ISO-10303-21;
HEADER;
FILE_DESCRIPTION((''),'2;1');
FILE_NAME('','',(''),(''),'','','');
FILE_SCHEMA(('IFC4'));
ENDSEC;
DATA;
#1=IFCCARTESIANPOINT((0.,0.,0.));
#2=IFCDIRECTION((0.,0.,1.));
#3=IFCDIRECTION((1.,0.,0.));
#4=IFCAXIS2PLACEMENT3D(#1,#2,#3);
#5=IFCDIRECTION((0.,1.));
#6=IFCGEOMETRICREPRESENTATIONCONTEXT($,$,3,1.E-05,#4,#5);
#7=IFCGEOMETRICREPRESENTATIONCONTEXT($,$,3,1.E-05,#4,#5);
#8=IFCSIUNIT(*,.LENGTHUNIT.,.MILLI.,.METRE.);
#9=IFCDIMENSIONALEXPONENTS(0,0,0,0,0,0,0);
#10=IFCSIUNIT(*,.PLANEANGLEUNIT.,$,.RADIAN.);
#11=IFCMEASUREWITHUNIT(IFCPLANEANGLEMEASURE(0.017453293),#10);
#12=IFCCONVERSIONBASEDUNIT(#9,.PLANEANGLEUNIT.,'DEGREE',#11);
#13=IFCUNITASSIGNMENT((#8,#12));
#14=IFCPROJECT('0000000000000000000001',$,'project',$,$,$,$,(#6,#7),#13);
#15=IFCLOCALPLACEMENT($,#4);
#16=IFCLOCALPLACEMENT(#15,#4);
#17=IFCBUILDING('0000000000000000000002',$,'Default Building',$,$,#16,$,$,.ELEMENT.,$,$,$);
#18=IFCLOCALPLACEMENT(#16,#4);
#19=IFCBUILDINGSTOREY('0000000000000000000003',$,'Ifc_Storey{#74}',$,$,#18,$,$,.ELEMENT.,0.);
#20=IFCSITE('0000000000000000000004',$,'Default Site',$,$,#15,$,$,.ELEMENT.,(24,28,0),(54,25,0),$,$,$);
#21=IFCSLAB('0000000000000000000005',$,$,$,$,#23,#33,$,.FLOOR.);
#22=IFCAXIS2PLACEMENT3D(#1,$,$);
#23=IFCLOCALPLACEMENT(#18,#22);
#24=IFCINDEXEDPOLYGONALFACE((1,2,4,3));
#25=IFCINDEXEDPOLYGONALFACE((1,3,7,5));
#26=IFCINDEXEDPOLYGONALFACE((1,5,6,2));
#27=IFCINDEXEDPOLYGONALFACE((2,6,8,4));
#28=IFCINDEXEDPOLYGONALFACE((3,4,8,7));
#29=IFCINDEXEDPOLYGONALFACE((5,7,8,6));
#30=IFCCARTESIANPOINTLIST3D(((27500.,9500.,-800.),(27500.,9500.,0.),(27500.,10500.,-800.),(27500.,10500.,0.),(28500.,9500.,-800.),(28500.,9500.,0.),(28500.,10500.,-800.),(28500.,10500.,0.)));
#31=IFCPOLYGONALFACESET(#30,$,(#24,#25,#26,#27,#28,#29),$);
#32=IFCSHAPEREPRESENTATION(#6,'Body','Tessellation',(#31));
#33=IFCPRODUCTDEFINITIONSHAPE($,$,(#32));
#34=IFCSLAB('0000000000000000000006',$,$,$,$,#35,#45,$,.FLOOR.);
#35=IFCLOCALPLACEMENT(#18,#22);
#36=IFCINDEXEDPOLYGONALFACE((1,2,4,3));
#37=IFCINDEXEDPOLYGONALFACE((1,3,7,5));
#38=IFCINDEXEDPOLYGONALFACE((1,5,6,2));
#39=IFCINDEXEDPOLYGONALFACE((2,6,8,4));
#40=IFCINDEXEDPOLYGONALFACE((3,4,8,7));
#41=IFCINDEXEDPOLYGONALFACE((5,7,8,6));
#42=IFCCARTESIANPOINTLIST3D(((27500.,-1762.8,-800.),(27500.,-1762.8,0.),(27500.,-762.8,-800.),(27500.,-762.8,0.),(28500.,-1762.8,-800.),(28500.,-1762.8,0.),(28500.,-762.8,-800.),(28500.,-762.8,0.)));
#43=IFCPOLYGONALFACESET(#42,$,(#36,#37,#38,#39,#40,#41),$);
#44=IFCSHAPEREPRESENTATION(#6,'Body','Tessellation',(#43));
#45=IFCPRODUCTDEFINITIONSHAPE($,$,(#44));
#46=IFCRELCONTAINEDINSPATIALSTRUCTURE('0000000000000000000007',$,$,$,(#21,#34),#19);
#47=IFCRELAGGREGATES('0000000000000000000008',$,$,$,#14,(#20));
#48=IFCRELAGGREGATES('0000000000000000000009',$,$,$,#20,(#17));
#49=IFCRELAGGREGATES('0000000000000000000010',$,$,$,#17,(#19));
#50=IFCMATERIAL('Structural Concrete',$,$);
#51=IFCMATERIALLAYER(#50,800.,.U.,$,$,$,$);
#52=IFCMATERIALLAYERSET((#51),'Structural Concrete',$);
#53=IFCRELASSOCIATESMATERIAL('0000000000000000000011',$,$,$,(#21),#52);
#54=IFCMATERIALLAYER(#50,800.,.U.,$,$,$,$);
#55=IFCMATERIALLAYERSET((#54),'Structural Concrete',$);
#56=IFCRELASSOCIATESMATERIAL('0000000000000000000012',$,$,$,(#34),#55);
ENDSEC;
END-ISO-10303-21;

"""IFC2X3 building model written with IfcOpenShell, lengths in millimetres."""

from ifc_helpers import new_model, entity, si_unit, converted_unit, direction, frame, origin_with_axes, place, context, project, spatial, polyline, outline, extrude, material, layer, layer_set, layer_usage, element, save


model = new_model("IFC2X3")

# Units and contexts
context_of_model_1 = context(None, 3, precision=1e-05, world=origin_with_axes(), true_north=direction((0.0, 1.0)))
context_of_model_2 = context(None, 3, precision=1e-05, world=origin_with_axes(), true_north=direction((0.0, 1.0)))
ifc_project = project(units=[si_unit("LENGTHUNIT", "METRE", prefix="MILLI"), converted_unit("PLANEANGLEUNIT", "DEGREE", entity("IfcPlaneAngleMeasure", 0.017453293), si_unit("PLANEANGLEUNIT", "RADIAN"), dimensions=[0, 0, 0, 0, 0, 0, 0])], contexts=[context_of_model_1, context_of_model_2])

# Site, building, storey
site_placement = place(None, origin_with_axes())
site = spatial("IfcSite", under=ifc_project, at=site_placement, Name="Default Site", CompositionType="ELEMENT", RefLatitude=(24, 28, 0), RefLongitude=(54, 25, 0))
building_placement = place(site_placement, origin_with_axes())
building = spatial("IfcBuilding", under=site, at=building_placement, Name="Default Building", CompositionType="ELEMENT")
storey_placement = place(building_placement, origin_with_axes())
storey = spatial("IfcBuildingStorey", under=building, at=storey_placement, Name="Ifc_Storey{#74}", CompositionType="ELEMENT", Elevation=0.0)

# Slabs
ifc_material_1 = material(Name="Structural Concrete")
ifc_layer_1 = layer(ifc_material_1, 800.0, ventilated="UNKNOWN")
ifc_layer_set_1 = layer_set([ifc_layer_1], Name="Structural Concrete")
ifc_layer_usage_1 = layer_usage(ifc_layer_set_1, "AXIS3", "NEGATIVE", 800.0)
slab_1_placement = place(storey_placement, frame((27500.0, 10500.0, -800.0), z_axis=(0.0, 0.0, 1.0), x_axis=(0.0, -1.0, 0.0)))
element("IfcSlab", 1, at=slab_1_placement, inside=storey, material=ifc_layer_usage_1, PredefinedType="FLOOR", context=context_of_model_1, shape_type="SweptSolid", body=[
    extrude(outline(polyline([(0.0, 0.0), (1000.0, 0.0), (1000.0, 1000.0), (0.0, 1000.0), (0.0, 0.0)])), origin_with_axes(), (0.0, 0.0, 1.0), 800.0),
])
ifc_layer_2 = layer(ifc_material_1, 800.0, ventilated="UNKNOWN")
ifc_layer_set_2 = layer_set([ifc_layer_2], Name="Structural Concrete")
ifc_layer_usage_2 = layer_usage(ifc_layer_set_2, "AXIS3", "NEGATIVE", 800.0)
slab_2_placement = place(storey_placement, frame((27500.0, -1762.8, -800.0), z_axis=(0.0, 0.0, 1.0), x_axis=(0.0, 1.0, 0.0)))
element("IfcSlab", 2, at=slab_2_placement, inside=storey, material=ifc_layer_usage_2, PredefinedType="FLOOR", context=context_of_model_1, shape_type="SweptSolid", body=[
    extrude(outline(polyline([(0.0, 0.0), (1000.0, 0.0), (1000.0, -1000.0), (0.0, -1000.0), (0.0, 0.0)])), origin_with_axes(), (0.0, 0.0, 1.0), 800.0),
])

save(model, "model.ifc")
